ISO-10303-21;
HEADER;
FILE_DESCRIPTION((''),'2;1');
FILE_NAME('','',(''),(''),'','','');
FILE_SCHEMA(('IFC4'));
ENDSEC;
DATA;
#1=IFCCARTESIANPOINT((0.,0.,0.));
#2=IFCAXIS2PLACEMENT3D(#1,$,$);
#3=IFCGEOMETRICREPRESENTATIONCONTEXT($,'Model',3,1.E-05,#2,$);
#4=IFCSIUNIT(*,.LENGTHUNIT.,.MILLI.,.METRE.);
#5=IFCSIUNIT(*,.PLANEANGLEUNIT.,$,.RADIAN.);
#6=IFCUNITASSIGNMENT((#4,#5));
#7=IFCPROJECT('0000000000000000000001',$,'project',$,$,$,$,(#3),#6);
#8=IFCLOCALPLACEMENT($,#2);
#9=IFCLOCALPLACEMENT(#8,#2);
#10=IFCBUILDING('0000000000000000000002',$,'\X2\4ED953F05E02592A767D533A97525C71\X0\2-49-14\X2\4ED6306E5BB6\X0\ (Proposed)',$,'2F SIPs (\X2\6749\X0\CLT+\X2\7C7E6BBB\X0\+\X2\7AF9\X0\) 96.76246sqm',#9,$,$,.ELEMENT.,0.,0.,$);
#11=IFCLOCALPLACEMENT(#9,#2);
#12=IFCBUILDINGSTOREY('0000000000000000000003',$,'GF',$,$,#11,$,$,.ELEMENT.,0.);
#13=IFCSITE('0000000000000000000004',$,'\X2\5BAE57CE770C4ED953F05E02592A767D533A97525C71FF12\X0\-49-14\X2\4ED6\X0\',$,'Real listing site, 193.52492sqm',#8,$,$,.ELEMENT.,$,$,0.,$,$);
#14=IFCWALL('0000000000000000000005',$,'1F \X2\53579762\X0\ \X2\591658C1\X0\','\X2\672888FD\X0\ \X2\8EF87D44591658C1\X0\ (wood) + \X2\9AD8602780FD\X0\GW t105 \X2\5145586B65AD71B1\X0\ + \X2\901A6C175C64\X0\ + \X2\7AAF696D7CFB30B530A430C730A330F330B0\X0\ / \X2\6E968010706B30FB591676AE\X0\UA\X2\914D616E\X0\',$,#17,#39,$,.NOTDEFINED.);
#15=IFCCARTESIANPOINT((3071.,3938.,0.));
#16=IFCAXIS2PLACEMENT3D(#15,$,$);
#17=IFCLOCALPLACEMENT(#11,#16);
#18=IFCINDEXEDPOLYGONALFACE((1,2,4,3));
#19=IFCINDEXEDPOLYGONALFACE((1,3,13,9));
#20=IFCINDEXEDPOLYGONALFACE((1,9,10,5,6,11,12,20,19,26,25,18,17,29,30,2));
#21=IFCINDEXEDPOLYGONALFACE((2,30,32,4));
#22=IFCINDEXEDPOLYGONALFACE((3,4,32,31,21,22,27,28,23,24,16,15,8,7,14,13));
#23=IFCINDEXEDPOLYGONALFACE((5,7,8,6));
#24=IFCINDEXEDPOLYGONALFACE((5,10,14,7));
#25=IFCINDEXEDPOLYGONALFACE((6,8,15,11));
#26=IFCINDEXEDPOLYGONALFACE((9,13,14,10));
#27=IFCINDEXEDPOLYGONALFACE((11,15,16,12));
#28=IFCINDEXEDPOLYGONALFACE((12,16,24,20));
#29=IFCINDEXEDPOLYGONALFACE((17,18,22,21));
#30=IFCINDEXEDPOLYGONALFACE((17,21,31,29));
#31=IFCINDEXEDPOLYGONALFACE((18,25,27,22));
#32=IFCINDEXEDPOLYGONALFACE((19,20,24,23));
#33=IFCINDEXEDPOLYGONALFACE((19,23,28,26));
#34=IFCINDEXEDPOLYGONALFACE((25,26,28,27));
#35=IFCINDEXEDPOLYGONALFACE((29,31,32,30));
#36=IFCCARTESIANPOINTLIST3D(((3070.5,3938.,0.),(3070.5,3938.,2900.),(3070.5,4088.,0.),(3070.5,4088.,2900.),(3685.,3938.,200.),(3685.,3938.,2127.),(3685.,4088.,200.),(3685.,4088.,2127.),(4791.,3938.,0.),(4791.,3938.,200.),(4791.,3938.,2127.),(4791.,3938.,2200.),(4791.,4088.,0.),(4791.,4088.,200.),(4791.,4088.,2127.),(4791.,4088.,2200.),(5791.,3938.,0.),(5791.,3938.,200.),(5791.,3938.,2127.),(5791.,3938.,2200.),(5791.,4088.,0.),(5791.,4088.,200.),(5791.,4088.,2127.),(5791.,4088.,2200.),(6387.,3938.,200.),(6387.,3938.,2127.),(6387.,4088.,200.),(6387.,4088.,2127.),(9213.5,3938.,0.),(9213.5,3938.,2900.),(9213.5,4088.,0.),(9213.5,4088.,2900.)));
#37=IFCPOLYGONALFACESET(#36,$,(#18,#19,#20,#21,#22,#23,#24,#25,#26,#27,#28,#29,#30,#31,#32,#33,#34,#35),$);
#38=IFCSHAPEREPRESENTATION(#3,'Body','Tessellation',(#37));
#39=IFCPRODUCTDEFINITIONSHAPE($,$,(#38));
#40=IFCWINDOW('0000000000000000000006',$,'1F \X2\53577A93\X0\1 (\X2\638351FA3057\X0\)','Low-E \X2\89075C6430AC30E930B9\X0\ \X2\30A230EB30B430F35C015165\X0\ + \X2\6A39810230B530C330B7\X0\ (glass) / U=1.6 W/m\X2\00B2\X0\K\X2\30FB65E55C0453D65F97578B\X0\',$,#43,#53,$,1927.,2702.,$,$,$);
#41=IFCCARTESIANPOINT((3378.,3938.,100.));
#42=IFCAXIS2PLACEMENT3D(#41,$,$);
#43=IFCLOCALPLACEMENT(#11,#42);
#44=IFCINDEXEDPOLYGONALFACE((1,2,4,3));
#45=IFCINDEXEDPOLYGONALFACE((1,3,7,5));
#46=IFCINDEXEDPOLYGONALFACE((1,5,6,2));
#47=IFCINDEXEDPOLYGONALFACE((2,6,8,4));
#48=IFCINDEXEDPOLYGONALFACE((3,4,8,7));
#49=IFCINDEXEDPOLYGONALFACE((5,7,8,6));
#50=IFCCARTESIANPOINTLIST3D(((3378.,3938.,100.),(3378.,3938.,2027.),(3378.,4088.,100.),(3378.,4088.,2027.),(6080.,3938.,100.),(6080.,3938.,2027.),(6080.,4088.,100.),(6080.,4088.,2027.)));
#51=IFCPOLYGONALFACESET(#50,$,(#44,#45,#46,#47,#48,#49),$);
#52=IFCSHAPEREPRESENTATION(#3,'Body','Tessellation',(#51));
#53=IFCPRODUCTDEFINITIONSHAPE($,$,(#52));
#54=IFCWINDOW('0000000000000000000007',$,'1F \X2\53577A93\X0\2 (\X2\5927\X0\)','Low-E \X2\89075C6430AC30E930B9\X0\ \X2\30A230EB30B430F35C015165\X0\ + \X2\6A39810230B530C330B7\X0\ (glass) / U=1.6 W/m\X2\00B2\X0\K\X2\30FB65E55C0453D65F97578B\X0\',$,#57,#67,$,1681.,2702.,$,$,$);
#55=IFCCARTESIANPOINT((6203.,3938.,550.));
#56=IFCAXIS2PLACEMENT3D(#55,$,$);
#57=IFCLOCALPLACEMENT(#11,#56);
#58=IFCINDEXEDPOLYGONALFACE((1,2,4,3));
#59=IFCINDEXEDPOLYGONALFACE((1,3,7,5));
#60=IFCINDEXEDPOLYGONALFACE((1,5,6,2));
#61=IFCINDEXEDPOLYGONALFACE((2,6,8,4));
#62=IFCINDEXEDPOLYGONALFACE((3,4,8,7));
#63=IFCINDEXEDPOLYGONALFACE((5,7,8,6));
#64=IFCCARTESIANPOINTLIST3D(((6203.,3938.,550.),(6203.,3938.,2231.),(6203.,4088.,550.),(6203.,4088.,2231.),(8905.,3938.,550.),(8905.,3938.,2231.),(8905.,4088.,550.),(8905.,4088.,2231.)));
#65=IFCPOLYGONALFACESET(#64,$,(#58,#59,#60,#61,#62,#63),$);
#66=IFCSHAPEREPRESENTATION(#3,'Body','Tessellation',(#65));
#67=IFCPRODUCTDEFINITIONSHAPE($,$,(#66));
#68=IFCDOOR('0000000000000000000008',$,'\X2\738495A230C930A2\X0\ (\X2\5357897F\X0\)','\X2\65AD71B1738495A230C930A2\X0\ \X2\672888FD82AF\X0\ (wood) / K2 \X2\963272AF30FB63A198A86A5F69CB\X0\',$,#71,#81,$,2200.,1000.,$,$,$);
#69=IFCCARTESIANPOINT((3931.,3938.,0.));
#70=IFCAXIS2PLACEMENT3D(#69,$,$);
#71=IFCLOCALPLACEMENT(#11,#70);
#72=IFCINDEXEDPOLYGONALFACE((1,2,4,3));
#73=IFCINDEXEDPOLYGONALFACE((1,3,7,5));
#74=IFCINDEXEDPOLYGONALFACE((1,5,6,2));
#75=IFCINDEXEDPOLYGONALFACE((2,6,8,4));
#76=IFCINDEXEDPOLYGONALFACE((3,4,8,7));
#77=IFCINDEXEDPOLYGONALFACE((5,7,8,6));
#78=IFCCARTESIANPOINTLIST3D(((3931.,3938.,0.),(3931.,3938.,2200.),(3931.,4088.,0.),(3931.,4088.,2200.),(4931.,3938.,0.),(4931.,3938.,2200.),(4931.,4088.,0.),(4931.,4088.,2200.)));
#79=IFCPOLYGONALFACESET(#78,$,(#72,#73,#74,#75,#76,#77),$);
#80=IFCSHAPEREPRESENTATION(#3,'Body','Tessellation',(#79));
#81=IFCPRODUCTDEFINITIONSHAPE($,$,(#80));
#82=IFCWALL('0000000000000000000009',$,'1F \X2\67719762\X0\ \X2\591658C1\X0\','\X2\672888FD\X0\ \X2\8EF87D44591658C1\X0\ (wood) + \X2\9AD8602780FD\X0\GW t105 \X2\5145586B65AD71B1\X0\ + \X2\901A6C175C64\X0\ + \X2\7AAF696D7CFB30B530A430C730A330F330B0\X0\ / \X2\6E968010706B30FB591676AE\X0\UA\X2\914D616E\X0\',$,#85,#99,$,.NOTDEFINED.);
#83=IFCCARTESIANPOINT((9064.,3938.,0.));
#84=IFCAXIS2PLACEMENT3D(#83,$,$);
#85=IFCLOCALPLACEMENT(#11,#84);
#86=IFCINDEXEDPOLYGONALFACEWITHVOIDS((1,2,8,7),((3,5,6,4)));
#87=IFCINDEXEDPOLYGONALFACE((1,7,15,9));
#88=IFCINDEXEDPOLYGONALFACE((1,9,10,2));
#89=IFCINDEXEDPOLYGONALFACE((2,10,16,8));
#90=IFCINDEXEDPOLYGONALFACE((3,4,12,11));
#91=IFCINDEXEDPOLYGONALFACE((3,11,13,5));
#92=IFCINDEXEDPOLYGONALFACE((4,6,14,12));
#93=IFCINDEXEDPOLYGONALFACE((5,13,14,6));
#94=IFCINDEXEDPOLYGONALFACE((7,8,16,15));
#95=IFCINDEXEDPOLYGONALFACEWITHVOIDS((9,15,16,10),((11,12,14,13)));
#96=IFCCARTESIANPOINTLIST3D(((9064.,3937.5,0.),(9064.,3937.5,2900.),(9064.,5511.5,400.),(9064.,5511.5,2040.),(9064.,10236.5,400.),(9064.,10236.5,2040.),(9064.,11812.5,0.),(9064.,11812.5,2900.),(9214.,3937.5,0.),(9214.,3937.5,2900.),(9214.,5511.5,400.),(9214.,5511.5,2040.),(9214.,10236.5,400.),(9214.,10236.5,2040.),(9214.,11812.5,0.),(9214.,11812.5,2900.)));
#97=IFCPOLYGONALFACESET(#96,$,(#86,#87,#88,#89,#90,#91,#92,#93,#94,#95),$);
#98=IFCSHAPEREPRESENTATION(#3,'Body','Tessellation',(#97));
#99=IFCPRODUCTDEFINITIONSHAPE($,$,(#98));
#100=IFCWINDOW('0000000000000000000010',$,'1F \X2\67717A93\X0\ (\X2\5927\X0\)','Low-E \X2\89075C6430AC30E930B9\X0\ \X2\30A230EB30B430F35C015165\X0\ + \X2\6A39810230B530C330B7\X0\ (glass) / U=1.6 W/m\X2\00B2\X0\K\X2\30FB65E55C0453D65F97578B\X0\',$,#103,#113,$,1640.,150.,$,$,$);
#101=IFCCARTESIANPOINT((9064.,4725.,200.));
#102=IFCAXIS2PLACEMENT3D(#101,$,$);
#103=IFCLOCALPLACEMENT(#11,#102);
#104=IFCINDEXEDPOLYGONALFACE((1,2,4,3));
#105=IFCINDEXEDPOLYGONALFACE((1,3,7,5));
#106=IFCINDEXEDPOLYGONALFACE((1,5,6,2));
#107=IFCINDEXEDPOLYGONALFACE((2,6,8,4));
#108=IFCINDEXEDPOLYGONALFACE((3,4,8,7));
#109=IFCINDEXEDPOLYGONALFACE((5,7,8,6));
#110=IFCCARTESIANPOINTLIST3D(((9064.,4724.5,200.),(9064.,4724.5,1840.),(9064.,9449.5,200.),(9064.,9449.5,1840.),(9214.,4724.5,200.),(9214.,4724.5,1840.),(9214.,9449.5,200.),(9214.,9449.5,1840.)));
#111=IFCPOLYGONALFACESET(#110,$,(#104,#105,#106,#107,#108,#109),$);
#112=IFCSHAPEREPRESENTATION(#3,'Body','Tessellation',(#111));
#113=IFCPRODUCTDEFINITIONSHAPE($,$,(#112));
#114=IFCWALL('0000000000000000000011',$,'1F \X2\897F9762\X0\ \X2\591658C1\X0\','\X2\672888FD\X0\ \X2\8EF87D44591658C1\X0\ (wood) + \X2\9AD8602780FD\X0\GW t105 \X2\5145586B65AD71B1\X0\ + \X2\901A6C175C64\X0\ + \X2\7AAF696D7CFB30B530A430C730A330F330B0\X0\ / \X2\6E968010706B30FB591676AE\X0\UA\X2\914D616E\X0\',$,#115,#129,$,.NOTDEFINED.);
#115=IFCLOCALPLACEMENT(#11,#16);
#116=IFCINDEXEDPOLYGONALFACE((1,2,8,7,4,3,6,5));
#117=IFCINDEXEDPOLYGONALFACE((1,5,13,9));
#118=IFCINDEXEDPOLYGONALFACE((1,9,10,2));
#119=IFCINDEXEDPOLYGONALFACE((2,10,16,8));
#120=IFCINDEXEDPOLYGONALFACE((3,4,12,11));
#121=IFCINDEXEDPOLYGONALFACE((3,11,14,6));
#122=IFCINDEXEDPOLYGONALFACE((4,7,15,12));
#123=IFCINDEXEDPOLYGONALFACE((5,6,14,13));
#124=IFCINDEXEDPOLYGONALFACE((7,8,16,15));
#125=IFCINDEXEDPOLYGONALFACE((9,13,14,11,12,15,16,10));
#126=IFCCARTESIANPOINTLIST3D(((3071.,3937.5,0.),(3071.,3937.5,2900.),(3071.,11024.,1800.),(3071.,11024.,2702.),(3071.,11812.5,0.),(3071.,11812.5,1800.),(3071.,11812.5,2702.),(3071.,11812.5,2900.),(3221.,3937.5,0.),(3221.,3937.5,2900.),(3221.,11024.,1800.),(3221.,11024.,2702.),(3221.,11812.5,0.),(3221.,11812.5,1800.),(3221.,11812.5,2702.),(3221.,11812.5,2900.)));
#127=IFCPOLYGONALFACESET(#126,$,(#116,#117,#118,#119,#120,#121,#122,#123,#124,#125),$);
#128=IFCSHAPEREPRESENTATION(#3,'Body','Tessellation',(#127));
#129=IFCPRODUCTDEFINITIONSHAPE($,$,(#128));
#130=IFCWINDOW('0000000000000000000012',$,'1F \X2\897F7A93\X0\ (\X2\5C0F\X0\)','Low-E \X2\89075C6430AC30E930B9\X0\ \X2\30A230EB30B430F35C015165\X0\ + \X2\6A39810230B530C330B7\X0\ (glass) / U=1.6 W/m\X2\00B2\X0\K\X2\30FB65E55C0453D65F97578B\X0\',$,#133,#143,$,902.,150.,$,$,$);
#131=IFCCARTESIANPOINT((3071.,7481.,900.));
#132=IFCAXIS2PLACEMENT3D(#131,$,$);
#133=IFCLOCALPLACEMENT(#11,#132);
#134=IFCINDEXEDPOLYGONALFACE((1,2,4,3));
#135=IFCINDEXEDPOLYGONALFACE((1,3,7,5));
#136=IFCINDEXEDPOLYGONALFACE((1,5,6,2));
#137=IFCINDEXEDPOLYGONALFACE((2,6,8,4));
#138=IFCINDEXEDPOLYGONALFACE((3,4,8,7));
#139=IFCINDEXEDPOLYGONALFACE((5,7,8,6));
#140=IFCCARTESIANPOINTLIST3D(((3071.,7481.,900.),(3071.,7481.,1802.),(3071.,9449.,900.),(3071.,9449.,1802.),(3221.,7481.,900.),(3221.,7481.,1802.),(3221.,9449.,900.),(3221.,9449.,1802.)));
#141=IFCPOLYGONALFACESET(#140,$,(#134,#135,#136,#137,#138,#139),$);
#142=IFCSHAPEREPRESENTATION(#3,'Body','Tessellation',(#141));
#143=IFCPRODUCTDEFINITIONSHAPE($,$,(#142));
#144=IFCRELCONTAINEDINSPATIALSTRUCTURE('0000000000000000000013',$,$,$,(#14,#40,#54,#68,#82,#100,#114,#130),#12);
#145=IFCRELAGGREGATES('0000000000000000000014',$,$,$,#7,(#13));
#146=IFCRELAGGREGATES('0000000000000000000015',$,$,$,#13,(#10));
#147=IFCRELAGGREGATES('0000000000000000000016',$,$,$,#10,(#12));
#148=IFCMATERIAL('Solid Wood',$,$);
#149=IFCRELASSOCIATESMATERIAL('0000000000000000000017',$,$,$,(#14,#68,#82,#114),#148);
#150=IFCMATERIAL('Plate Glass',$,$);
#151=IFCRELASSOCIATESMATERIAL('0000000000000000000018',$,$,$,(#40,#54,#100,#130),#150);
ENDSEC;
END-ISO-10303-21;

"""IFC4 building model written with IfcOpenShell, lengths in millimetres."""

from ifc_helpers import new_model, si_unit, frame, frame_2d, origin, place, context, project, spatial, rectangle, extrude, material, element, fill, save


model = new_model("IFC4")

# Units and contexts
model_context = context("Model", 3, precision=1e-05, world=origin())
ifc_project = project(units=[si_unit("LENGTHUNIT", "METRE", prefix="MILLI"), si_unit("PLANEANGLEUNIT", "RADIAN")], contexts=[model_context])

# Site, building, storey
site_placement = place(None, origin())
site = spatial("IfcSite", under=ifc_project, at=site_placement, Name="宮城県仙台市太白区青山２-49-14他", ObjectType="Real listing site, 193.52492sqm", CompositionType="ELEMENT", RefElevation=0.0)
building_placement = place(site_placement, origin())
building = spatial("IfcBuilding", under=site, at=building_placement, Name="仙台市太白区青山2-49-14他の家 (Proposed)", ObjectType="2F SIPs (杉CLT+籾殻+竹) 96.76246sqm", CompositionType="ELEMENT", ElevationOfRefHeight=0.0, ElevationOfTerrain=0.0)
storey_placement = place(building_placement, origin())
storey = spatial("IfcBuildingStorey", under=building, at=storey_placement, Name="GF", CompositionType="ELEMENT", Elevation=0.0)

# Shared definitions
ifc_material_1 = material(Name="Solid Wood")

# Wall, openings, windows, door
wall_1_placement = place(storey_placement, frame((3071.0, 3938.0, 0.0)))
wall_1 = element("IfcWall", 1, at=wall_1_placement, inside=storey, material=ifc_material_1, Name="1F 南面 外壁", Description="木製 軸組外壁 (wood) + 高性能GW t105 充填断熱 + 通気層 + 窯業系サイディング / 準耐火・外皮UA配慮", PredefinedType="NOTDEFINED", context=model_context, shape_type="SweptSolid", body=[
    extrude(rectangle(XDim=6143.0, YDim=150.0, at=frame_2d((3071.0, 75.0))), frame((3071.0, 3938.0, 0.0)), (0.0, 0.0, 1.0), 2900.0),
])
opening_1_placement = place(storey_placement, frame((3378.0, 3938.0, 100.0)))
opening_1 = element("IfcOpeningElement", 2, at=opening_1_placement, cuts=wall_1, PredefinedType="NOTDEFINED", context=model_context, shape_type="SweptSolid", body=[
    extrude(rectangle(XDim=2702.0, YDim=150.0, at=frame_2d((1351.0, 75.0))), frame((3378.0, 3938.0, 100.0)), (0.0, 0.0, 1.0), 1927.0),
])
opening_2_placement = place(storey_placement, frame((6203.0, 3938.0, 550.0)))
opening_2 = element("IfcOpeningElement", 3, at=opening_2_placement, cuts=wall_1, PredefinedType="NOTDEFINED", context=model_context, shape_type="SweptSolid", body=[
    extrude(rectangle(XDim=2702.0, YDim=150.0, at=frame_2d((1351.0, 75.0))), frame((6203.0, 3938.0, 550.0)), (0.0, 0.0, 1.0), 1681.0),
])
opening_3_placement = place(storey_placement, frame((3931.0, 3938.0, 0.0)))
opening_3 = element("IfcOpeningElement", 4, at=opening_3_placement, cuts=wall_1, PredefinedType="NOTDEFINED", context=model_context, shape_type="SweptSolid", body=[
    extrude(rectangle(XDim=1000.0, YDim=150.0, at=frame_2d((500.0, 75.0))), frame((3931.0, 3938.0, 0.0)), (0.0, 0.0, 1.0), 2200.0),
])
ifc_material_2 = material(Name="Plate Glass")
window_1_placement = place(storey_placement, frame((3378.0, 3938.0, 100.0)))
window_1 = element("IfcWindow", 5, at=window_1_placement, inside=storey, material=ifc_material_2, Name="1F 南窓1 (掃出し)", Description="Low-E 複層ガラス アルゴン封入 + 樹脂サッシ (glass) / U=1.6 W/m²K・日射取得型", OverallHeight=1927.0, OverallWidth=2702.0, context=model_context, shape_type="SweptSolid", body=[
    extrude(rectangle(XDim=2702.0, YDim=150.0, at=frame_2d((1351.0, 75.0))), frame((3378.0, 3938.0, 100.0)), (0.0, 0.0, 1.0), 1927.0),
])
fill(opening_1, window_1)
window_2_placement = place(storey_placement, frame((6203.0, 3938.0, 550.0)))
window_2 = element("IfcWindow", 6, at=window_2_placement, inside=storey, material=ifc_material_2, Name="1F 南窓2 (大)", Description="Low-E 複層ガラス アルゴン封入 + 樹脂サッシ (glass) / U=1.6 W/m²K・日射取得型", OverallHeight=1681.0, OverallWidth=2702.0, context=model_context, shape_type="SweptSolid", body=[
    extrude(rectangle(XDim=2702.0, YDim=150.0, at=frame_2d((1351.0, 75.0))), frame((6203.0, 3938.0, 550.0)), (0.0, 0.0, 1.0), 1681.0),
])
fill(opening_2, window_2)
door_placement = place(storey_placement, frame((3931.0, 3938.0, 0.0)))
door = element("IfcDoor", 7, at=door_placement, inside=storey, material=ifc_material_1, Name="玄関ドア (南西)", Description="断熱玄関ドア 木製芯 (wood) / K2 防犯・採風機構", OverallHeight=2200.0, OverallWidth=1000.0, context=model_context, shape_type="SweptSolid", body=[
    extrude(rectangle(XDim=1000.0, YDim=150.0, at=frame_2d((500.0, 75.0))), frame((3931.0, 3938.0, 0.0)), (0.0, 0.0, 1.0), 2200.0),
])
fill(opening_3, door)

# Walls, openings, windows
wall_2_placement = place(storey_placement, frame((9064.0, 3938.0, 0.0)))
wall_2 = element("IfcWall", 8, at=wall_2_placement, inside=storey, material=ifc_material_1, Name="1F 東面 外壁", Description="木製 軸組外壁 (wood) + 高性能GW t105 充填断熱 + 通気層 + 窯業系サイディング / 準耐火・外皮UA配慮", PredefinedType="NOTDEFINED", context=model_context, shape_type="SweptSolid", body=[
    extrude(rectangle(XDim=150.0, YDim=7875.0, at=frame_2d((75.0, 3937.0))), frame((9064.0, 3938.0, 0.0)), (0.0, 0.0, 1.0), 2900.0),
])
opening_4_placement = place(storey_placement, frame((9064.0, 4725.0, 200.0)))
opening_4 = element("IfcOpeningElement", 9, at=opening_4_placement, cuts=wall_2, PredefinedType="NOTDEFINED", context=model_context, shape_type="SweptSolid", body=[
    extrude(rectangle(XDim=150.0, YDim=4725.0, at=frame_2d((75.0, 2362.0))), frame((9064.0, 4725.0, 200.0)), (0.0, 0.0, 1.0), 1640.0),
])
window_3_placement = place(storey_placement, frame((9064.0, 4725.0, 200.0)))
window_3 = element("IfcWindow", 10, at=window_3_placement, inside=storey, material=ifc_material_2, Name="1F 東窓 (大)", Description="Low-E 複層ガラス アルゴン封入 + 樹脂サッシ (glass) / U=1.6 W/m²K・日射取得型", OverallHeight=1640.0, OverallWidth=150.0, context=model_context, shape_type="SweptSolid", body=[
    extrude(rectangle(XDim=150.0, YDim=4725.0, at=frame_2d((75.0, 2362.0))), frame((9064.0, 4725.0, 200.0)), (0.0, 0.0, 1.0), 1640.0),
])
fill(opening_4, window_3)
wall_3_placement = place(storey_placement, frame((3071.0, 3938.0, 0.0)))
wall_3 = element("IfcWall", 11, at=wall_3_placement, inside=storey, material=ifc_material_1, Name="1F 西面 外壁", Description="木製 軸組外壁 (wood) + 高性能GW t105 充填断熱 + 通気層 + 窯業系サイディング / 準耐火・外皮UA配慮", PredefinedType="NOTDEFINED", context=model_context, shape_type="SweptSolid", body=[
    extrude(rectangle(XDim=150.0, YDim=7875.0, at=frame_2d((75.0, 3937.0))), frame((3071.0, 3938.0, 0.0)), (0.0, 0.0, 1.0), 2900.0),
])
opening_5_placement = place(storey_placement, frame((3071.0, 7481.0, 900.0)))
opening_5 = element("IfcOpeningElement", 12, at=opening_5_placement, cuts=wall_3, PredefinedType="NOTDEFINED", context=model_context, shape_type="SweptSolid", body=[
    extrude(rectangle(XDim=150.0, YDim=1968.0, at=frame_2d((75.0, 984.0))), frame((3071.0, 7481.0, 900.0)), (0.0, 0.0, 1.0), 902.0),
])
window_4_placement = place(storey_placement, frame((3071.0, 7481.0, 900.0)))
window_4 = element("IfcWindow", 13, at=window_4_placement, inside=storey, material=ifc_material_2, Name="1F 西窓 (小)", Description="Low-E 複層ガラス アルゴン封入 + 樹脂サッシ (glass) / U=1.6 W/m²K・日射取得型", OverallHeight=902.0, OverallWidth=150.0, context=model_context, shape_type="SweptSolid", body=[
    extrude(rectangle(XDim=150.0, YDim=1968.0, at=frame_2d((75.0, 984.0))), frame((3071.0, 7481.0, 900.0)), (0.0, 0.0, 1.0), 902.0),
])
fill(opening_5, window_4)

save(model, "model.ifc")
